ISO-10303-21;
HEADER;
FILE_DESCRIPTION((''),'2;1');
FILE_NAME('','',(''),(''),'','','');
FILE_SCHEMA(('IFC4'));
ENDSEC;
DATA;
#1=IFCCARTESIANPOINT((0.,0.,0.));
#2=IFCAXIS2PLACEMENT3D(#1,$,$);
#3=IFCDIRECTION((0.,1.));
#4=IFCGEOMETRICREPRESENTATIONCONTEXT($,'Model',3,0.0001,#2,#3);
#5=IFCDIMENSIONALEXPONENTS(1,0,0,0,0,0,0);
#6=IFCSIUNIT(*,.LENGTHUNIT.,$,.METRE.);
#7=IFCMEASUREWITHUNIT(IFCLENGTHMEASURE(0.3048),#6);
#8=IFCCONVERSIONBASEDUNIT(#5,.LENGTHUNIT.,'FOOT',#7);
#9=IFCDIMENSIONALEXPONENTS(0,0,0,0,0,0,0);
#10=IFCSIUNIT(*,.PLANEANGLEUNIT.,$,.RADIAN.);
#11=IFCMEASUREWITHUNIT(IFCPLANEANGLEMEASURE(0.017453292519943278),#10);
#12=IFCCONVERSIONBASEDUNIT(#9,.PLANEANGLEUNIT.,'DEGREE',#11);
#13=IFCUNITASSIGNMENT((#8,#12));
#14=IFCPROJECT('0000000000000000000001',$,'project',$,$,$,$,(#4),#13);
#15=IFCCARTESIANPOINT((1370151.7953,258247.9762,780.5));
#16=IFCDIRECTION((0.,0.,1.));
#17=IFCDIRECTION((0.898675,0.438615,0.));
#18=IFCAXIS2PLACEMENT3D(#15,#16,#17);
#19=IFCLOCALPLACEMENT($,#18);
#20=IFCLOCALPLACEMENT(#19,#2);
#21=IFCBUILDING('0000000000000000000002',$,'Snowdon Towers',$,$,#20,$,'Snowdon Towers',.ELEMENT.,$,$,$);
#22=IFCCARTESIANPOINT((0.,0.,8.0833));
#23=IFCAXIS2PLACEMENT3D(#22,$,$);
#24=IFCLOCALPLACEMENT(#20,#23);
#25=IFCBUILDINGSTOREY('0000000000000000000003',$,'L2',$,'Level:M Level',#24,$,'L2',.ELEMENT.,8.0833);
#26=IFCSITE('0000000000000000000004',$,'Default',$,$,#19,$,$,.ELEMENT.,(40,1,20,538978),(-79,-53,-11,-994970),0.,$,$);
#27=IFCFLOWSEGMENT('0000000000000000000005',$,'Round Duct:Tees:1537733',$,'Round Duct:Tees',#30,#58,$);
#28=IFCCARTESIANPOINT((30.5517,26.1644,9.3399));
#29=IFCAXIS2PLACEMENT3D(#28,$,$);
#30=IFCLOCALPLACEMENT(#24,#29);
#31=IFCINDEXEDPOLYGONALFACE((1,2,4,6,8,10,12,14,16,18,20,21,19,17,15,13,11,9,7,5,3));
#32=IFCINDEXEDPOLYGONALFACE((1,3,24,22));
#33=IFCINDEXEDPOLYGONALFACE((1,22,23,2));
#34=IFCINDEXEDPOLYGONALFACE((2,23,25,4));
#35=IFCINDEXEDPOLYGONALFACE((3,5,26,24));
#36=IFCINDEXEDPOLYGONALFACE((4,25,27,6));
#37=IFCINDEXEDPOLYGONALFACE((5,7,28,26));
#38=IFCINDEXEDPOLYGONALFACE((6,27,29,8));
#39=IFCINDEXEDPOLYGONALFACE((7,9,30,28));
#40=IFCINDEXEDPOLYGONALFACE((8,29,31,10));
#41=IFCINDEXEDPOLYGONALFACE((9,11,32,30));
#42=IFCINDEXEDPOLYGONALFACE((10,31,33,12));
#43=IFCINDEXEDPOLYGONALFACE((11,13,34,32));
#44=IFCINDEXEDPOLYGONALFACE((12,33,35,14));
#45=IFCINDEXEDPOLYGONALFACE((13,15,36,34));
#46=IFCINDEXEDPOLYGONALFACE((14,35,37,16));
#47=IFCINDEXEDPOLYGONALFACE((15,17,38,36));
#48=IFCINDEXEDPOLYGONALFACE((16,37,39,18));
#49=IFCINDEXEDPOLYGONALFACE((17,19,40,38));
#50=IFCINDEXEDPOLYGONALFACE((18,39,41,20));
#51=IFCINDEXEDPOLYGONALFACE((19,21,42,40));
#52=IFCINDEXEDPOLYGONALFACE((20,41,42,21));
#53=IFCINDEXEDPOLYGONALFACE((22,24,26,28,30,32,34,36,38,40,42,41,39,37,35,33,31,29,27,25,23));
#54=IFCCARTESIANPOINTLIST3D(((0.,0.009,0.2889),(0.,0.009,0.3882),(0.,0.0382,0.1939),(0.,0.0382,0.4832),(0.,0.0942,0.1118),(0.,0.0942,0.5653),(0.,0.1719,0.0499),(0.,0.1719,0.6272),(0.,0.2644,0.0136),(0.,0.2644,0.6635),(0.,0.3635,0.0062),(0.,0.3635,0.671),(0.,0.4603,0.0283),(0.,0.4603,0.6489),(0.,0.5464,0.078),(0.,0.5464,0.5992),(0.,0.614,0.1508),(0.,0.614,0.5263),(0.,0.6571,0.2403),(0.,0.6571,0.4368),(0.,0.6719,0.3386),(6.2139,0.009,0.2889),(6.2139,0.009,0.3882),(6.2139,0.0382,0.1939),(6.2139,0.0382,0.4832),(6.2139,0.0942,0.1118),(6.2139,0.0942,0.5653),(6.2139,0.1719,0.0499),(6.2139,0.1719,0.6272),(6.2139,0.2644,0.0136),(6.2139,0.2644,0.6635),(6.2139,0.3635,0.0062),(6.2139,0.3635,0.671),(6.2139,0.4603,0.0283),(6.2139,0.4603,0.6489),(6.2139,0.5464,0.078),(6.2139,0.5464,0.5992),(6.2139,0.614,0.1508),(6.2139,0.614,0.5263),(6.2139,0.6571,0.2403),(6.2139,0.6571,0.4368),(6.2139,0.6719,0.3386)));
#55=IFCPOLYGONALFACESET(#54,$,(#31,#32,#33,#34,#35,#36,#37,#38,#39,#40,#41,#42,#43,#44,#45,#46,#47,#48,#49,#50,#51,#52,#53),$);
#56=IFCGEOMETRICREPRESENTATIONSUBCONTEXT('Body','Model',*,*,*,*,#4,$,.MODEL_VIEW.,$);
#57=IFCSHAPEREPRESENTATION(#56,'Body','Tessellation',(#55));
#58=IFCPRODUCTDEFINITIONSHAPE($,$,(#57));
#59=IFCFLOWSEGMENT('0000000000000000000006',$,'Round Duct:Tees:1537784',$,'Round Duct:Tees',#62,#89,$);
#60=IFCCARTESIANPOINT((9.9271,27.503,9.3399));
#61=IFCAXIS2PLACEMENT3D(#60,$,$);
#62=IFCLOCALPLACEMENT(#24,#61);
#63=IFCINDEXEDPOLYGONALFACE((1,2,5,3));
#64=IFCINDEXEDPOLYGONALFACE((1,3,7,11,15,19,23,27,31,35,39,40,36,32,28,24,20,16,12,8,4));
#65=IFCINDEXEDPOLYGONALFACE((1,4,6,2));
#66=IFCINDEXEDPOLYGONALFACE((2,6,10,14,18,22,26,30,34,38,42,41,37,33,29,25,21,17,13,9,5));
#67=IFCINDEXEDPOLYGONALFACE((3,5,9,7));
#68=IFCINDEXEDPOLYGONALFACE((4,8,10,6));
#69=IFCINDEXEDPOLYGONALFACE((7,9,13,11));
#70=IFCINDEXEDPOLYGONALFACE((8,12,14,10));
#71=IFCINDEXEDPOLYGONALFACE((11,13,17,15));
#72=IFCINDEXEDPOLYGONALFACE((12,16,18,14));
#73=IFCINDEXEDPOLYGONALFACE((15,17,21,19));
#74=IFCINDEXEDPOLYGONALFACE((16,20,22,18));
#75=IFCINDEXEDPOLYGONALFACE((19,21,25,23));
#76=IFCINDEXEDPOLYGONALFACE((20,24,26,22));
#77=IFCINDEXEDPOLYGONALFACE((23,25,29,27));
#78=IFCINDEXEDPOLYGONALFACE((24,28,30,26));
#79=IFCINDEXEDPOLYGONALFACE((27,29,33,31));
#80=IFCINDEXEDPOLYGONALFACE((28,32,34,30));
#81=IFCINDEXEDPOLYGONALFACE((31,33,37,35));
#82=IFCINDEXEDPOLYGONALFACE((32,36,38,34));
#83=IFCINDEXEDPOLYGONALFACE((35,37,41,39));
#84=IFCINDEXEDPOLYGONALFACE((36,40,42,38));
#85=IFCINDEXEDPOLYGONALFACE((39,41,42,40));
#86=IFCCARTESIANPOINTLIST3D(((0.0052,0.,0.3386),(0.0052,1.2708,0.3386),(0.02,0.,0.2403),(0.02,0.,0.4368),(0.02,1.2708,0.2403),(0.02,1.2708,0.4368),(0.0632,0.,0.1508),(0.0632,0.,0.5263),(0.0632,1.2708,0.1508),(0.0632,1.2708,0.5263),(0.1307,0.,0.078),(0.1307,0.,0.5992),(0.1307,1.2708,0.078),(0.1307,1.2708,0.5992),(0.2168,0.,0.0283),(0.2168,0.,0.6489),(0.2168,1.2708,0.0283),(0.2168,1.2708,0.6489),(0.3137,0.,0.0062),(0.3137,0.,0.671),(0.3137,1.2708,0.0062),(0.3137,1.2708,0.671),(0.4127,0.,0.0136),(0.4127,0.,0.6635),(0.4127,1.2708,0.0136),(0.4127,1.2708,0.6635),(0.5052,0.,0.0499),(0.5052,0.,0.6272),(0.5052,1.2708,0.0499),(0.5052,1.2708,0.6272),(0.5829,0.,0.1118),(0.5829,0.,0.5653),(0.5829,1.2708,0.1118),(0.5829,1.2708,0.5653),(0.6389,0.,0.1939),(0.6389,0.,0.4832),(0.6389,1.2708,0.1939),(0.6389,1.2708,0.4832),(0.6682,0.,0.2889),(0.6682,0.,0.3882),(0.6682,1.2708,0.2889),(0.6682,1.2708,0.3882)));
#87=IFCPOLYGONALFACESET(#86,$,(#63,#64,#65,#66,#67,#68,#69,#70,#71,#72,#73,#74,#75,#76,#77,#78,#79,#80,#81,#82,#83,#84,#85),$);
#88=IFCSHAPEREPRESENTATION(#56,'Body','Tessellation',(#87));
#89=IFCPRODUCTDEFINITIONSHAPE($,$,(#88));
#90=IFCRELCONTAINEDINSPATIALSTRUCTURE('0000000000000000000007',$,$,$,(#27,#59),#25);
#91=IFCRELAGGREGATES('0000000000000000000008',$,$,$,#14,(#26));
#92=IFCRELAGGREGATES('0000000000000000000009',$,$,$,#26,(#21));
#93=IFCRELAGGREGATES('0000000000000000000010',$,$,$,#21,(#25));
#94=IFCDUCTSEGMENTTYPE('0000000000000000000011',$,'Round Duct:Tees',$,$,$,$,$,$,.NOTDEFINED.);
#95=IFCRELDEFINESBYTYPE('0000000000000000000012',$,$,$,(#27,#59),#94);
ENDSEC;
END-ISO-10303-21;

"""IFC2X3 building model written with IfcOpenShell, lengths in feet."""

from ifc_helpers import new_model, entity, si_unit, converted_unit, direction, frame, frame_2d, origin, place, context, subcontext, project, spatial, circle, extrude, type_object, element, save


model = new_model("IFC2X3")

# Units and contexts
model_context = context("Model", 3, precision=0.0001, world=origin(), true_north=direction((0.0, 1.0)))
body_context = subcontext(model_context, "Body", "Model", "MODEL_VIEW")
ifc_project = project(units=[converted_unit("LENGTHUNIT", "FOOT", entity("IfcLengthMeasure", 0.3048), si_unit("LENGTHUNIT", "METRE"), dimensions=[1, 0, 0, 0, 0, 0, 0]), converted_unit("PLANEANGLEUNIT", "DEGREE", entity("IfcPlaneAngleMeasure", 0.017453292519943278), si_unit("PLANEANGLEUNIT", "RADIAN"), dimensions=[0, 0, 0, 0, 0, 0, 0])], contexts=[model_context])

# Site, building, storey
site_placement = place(None, frame((1370151.7953, 258247.9762, 780.5), z_axis=(0.0, 0.0, 1.0), x_axis=(0.898675, 0.438615, 0.0)))
site = spatial("IfcSite", under=ifc_project, at=site_placement, Name="Default", CompositionType="ELEMENT", RefLatitude=(40, 1, 20, 538978), RefLongitude=(-79, -53, -11, -994970), RefElevation=0.0)
building_placement = place(site_placement, origin())
building = spatial("IfcBuilding", under=site, at=building_placement, Name="Snowdon Towers", LongName="Snowdon Towers", CompositionType="ELEMENT")
storey_placement = place(building_placement, frame((0.0, 0.0, 8.0833)))
storey = spatial("IfcBuildingStorey", under=building, at=storey_placement, Name="L2", ObjectType="Level:M Level", LongName="L2", CompositionType="ELEMENT", Elevation=8.0833)

# Flow segments
duct_segment_type = type_object("IfcDuctSegmentType", Name="Round Duct:Tees", PredefinedType="NOTDEFINED")
flow_segment_1_placement = place(storey_placement, frame((30.5517, 26.1644, 9.3399)))
element("IfcFlowSegment", 1, at=flow_segment_1_placement, inside=storey, type_object=duct_segment_type, Name="Round Duct:Tees:1537733", ObjectType="Round Duct:Tees", context=body_context, shape_type="SweptSolid", body=[
    extrude(circle(Radius=0.3333, at=frame_2d((0.0, 0.0), x_axis=(1.0, 0.0))), frame((0.0, 0.3386, 0.3386), z_axis=(1.0, 0.0, 0.0), x_axis=(0.0, 1.0, 0.0)), (0.0, 0.0, 1.0), 6.2139),
])
flow_segment_2_placement = place(storey_placement, frame((9.9271, 27.503, 9.3399)))
element("IfcFlowSegment", 2, at=flow_segment_2_placement, inside=storey, type_object=duct_segment_type, Name="Round Duct:Tees:1537784", ObjectType="Round Duct:Tees", context=body_context, shape_type="SweptSolid", body=[
    extrude(circle(Radius=0.3333, at=frame_2d((0.0, 0.0), x_axis=(1.0, 0.0))), frame((0.3386, 0.0, 0.3386), z_axis=(0.0, 1.0, 0.0), x_axis=(-1.0, 0.0, 0.0)), (0.0, 0.0, 1.0), 1.2708),
])

save(model, "model.ifc")
